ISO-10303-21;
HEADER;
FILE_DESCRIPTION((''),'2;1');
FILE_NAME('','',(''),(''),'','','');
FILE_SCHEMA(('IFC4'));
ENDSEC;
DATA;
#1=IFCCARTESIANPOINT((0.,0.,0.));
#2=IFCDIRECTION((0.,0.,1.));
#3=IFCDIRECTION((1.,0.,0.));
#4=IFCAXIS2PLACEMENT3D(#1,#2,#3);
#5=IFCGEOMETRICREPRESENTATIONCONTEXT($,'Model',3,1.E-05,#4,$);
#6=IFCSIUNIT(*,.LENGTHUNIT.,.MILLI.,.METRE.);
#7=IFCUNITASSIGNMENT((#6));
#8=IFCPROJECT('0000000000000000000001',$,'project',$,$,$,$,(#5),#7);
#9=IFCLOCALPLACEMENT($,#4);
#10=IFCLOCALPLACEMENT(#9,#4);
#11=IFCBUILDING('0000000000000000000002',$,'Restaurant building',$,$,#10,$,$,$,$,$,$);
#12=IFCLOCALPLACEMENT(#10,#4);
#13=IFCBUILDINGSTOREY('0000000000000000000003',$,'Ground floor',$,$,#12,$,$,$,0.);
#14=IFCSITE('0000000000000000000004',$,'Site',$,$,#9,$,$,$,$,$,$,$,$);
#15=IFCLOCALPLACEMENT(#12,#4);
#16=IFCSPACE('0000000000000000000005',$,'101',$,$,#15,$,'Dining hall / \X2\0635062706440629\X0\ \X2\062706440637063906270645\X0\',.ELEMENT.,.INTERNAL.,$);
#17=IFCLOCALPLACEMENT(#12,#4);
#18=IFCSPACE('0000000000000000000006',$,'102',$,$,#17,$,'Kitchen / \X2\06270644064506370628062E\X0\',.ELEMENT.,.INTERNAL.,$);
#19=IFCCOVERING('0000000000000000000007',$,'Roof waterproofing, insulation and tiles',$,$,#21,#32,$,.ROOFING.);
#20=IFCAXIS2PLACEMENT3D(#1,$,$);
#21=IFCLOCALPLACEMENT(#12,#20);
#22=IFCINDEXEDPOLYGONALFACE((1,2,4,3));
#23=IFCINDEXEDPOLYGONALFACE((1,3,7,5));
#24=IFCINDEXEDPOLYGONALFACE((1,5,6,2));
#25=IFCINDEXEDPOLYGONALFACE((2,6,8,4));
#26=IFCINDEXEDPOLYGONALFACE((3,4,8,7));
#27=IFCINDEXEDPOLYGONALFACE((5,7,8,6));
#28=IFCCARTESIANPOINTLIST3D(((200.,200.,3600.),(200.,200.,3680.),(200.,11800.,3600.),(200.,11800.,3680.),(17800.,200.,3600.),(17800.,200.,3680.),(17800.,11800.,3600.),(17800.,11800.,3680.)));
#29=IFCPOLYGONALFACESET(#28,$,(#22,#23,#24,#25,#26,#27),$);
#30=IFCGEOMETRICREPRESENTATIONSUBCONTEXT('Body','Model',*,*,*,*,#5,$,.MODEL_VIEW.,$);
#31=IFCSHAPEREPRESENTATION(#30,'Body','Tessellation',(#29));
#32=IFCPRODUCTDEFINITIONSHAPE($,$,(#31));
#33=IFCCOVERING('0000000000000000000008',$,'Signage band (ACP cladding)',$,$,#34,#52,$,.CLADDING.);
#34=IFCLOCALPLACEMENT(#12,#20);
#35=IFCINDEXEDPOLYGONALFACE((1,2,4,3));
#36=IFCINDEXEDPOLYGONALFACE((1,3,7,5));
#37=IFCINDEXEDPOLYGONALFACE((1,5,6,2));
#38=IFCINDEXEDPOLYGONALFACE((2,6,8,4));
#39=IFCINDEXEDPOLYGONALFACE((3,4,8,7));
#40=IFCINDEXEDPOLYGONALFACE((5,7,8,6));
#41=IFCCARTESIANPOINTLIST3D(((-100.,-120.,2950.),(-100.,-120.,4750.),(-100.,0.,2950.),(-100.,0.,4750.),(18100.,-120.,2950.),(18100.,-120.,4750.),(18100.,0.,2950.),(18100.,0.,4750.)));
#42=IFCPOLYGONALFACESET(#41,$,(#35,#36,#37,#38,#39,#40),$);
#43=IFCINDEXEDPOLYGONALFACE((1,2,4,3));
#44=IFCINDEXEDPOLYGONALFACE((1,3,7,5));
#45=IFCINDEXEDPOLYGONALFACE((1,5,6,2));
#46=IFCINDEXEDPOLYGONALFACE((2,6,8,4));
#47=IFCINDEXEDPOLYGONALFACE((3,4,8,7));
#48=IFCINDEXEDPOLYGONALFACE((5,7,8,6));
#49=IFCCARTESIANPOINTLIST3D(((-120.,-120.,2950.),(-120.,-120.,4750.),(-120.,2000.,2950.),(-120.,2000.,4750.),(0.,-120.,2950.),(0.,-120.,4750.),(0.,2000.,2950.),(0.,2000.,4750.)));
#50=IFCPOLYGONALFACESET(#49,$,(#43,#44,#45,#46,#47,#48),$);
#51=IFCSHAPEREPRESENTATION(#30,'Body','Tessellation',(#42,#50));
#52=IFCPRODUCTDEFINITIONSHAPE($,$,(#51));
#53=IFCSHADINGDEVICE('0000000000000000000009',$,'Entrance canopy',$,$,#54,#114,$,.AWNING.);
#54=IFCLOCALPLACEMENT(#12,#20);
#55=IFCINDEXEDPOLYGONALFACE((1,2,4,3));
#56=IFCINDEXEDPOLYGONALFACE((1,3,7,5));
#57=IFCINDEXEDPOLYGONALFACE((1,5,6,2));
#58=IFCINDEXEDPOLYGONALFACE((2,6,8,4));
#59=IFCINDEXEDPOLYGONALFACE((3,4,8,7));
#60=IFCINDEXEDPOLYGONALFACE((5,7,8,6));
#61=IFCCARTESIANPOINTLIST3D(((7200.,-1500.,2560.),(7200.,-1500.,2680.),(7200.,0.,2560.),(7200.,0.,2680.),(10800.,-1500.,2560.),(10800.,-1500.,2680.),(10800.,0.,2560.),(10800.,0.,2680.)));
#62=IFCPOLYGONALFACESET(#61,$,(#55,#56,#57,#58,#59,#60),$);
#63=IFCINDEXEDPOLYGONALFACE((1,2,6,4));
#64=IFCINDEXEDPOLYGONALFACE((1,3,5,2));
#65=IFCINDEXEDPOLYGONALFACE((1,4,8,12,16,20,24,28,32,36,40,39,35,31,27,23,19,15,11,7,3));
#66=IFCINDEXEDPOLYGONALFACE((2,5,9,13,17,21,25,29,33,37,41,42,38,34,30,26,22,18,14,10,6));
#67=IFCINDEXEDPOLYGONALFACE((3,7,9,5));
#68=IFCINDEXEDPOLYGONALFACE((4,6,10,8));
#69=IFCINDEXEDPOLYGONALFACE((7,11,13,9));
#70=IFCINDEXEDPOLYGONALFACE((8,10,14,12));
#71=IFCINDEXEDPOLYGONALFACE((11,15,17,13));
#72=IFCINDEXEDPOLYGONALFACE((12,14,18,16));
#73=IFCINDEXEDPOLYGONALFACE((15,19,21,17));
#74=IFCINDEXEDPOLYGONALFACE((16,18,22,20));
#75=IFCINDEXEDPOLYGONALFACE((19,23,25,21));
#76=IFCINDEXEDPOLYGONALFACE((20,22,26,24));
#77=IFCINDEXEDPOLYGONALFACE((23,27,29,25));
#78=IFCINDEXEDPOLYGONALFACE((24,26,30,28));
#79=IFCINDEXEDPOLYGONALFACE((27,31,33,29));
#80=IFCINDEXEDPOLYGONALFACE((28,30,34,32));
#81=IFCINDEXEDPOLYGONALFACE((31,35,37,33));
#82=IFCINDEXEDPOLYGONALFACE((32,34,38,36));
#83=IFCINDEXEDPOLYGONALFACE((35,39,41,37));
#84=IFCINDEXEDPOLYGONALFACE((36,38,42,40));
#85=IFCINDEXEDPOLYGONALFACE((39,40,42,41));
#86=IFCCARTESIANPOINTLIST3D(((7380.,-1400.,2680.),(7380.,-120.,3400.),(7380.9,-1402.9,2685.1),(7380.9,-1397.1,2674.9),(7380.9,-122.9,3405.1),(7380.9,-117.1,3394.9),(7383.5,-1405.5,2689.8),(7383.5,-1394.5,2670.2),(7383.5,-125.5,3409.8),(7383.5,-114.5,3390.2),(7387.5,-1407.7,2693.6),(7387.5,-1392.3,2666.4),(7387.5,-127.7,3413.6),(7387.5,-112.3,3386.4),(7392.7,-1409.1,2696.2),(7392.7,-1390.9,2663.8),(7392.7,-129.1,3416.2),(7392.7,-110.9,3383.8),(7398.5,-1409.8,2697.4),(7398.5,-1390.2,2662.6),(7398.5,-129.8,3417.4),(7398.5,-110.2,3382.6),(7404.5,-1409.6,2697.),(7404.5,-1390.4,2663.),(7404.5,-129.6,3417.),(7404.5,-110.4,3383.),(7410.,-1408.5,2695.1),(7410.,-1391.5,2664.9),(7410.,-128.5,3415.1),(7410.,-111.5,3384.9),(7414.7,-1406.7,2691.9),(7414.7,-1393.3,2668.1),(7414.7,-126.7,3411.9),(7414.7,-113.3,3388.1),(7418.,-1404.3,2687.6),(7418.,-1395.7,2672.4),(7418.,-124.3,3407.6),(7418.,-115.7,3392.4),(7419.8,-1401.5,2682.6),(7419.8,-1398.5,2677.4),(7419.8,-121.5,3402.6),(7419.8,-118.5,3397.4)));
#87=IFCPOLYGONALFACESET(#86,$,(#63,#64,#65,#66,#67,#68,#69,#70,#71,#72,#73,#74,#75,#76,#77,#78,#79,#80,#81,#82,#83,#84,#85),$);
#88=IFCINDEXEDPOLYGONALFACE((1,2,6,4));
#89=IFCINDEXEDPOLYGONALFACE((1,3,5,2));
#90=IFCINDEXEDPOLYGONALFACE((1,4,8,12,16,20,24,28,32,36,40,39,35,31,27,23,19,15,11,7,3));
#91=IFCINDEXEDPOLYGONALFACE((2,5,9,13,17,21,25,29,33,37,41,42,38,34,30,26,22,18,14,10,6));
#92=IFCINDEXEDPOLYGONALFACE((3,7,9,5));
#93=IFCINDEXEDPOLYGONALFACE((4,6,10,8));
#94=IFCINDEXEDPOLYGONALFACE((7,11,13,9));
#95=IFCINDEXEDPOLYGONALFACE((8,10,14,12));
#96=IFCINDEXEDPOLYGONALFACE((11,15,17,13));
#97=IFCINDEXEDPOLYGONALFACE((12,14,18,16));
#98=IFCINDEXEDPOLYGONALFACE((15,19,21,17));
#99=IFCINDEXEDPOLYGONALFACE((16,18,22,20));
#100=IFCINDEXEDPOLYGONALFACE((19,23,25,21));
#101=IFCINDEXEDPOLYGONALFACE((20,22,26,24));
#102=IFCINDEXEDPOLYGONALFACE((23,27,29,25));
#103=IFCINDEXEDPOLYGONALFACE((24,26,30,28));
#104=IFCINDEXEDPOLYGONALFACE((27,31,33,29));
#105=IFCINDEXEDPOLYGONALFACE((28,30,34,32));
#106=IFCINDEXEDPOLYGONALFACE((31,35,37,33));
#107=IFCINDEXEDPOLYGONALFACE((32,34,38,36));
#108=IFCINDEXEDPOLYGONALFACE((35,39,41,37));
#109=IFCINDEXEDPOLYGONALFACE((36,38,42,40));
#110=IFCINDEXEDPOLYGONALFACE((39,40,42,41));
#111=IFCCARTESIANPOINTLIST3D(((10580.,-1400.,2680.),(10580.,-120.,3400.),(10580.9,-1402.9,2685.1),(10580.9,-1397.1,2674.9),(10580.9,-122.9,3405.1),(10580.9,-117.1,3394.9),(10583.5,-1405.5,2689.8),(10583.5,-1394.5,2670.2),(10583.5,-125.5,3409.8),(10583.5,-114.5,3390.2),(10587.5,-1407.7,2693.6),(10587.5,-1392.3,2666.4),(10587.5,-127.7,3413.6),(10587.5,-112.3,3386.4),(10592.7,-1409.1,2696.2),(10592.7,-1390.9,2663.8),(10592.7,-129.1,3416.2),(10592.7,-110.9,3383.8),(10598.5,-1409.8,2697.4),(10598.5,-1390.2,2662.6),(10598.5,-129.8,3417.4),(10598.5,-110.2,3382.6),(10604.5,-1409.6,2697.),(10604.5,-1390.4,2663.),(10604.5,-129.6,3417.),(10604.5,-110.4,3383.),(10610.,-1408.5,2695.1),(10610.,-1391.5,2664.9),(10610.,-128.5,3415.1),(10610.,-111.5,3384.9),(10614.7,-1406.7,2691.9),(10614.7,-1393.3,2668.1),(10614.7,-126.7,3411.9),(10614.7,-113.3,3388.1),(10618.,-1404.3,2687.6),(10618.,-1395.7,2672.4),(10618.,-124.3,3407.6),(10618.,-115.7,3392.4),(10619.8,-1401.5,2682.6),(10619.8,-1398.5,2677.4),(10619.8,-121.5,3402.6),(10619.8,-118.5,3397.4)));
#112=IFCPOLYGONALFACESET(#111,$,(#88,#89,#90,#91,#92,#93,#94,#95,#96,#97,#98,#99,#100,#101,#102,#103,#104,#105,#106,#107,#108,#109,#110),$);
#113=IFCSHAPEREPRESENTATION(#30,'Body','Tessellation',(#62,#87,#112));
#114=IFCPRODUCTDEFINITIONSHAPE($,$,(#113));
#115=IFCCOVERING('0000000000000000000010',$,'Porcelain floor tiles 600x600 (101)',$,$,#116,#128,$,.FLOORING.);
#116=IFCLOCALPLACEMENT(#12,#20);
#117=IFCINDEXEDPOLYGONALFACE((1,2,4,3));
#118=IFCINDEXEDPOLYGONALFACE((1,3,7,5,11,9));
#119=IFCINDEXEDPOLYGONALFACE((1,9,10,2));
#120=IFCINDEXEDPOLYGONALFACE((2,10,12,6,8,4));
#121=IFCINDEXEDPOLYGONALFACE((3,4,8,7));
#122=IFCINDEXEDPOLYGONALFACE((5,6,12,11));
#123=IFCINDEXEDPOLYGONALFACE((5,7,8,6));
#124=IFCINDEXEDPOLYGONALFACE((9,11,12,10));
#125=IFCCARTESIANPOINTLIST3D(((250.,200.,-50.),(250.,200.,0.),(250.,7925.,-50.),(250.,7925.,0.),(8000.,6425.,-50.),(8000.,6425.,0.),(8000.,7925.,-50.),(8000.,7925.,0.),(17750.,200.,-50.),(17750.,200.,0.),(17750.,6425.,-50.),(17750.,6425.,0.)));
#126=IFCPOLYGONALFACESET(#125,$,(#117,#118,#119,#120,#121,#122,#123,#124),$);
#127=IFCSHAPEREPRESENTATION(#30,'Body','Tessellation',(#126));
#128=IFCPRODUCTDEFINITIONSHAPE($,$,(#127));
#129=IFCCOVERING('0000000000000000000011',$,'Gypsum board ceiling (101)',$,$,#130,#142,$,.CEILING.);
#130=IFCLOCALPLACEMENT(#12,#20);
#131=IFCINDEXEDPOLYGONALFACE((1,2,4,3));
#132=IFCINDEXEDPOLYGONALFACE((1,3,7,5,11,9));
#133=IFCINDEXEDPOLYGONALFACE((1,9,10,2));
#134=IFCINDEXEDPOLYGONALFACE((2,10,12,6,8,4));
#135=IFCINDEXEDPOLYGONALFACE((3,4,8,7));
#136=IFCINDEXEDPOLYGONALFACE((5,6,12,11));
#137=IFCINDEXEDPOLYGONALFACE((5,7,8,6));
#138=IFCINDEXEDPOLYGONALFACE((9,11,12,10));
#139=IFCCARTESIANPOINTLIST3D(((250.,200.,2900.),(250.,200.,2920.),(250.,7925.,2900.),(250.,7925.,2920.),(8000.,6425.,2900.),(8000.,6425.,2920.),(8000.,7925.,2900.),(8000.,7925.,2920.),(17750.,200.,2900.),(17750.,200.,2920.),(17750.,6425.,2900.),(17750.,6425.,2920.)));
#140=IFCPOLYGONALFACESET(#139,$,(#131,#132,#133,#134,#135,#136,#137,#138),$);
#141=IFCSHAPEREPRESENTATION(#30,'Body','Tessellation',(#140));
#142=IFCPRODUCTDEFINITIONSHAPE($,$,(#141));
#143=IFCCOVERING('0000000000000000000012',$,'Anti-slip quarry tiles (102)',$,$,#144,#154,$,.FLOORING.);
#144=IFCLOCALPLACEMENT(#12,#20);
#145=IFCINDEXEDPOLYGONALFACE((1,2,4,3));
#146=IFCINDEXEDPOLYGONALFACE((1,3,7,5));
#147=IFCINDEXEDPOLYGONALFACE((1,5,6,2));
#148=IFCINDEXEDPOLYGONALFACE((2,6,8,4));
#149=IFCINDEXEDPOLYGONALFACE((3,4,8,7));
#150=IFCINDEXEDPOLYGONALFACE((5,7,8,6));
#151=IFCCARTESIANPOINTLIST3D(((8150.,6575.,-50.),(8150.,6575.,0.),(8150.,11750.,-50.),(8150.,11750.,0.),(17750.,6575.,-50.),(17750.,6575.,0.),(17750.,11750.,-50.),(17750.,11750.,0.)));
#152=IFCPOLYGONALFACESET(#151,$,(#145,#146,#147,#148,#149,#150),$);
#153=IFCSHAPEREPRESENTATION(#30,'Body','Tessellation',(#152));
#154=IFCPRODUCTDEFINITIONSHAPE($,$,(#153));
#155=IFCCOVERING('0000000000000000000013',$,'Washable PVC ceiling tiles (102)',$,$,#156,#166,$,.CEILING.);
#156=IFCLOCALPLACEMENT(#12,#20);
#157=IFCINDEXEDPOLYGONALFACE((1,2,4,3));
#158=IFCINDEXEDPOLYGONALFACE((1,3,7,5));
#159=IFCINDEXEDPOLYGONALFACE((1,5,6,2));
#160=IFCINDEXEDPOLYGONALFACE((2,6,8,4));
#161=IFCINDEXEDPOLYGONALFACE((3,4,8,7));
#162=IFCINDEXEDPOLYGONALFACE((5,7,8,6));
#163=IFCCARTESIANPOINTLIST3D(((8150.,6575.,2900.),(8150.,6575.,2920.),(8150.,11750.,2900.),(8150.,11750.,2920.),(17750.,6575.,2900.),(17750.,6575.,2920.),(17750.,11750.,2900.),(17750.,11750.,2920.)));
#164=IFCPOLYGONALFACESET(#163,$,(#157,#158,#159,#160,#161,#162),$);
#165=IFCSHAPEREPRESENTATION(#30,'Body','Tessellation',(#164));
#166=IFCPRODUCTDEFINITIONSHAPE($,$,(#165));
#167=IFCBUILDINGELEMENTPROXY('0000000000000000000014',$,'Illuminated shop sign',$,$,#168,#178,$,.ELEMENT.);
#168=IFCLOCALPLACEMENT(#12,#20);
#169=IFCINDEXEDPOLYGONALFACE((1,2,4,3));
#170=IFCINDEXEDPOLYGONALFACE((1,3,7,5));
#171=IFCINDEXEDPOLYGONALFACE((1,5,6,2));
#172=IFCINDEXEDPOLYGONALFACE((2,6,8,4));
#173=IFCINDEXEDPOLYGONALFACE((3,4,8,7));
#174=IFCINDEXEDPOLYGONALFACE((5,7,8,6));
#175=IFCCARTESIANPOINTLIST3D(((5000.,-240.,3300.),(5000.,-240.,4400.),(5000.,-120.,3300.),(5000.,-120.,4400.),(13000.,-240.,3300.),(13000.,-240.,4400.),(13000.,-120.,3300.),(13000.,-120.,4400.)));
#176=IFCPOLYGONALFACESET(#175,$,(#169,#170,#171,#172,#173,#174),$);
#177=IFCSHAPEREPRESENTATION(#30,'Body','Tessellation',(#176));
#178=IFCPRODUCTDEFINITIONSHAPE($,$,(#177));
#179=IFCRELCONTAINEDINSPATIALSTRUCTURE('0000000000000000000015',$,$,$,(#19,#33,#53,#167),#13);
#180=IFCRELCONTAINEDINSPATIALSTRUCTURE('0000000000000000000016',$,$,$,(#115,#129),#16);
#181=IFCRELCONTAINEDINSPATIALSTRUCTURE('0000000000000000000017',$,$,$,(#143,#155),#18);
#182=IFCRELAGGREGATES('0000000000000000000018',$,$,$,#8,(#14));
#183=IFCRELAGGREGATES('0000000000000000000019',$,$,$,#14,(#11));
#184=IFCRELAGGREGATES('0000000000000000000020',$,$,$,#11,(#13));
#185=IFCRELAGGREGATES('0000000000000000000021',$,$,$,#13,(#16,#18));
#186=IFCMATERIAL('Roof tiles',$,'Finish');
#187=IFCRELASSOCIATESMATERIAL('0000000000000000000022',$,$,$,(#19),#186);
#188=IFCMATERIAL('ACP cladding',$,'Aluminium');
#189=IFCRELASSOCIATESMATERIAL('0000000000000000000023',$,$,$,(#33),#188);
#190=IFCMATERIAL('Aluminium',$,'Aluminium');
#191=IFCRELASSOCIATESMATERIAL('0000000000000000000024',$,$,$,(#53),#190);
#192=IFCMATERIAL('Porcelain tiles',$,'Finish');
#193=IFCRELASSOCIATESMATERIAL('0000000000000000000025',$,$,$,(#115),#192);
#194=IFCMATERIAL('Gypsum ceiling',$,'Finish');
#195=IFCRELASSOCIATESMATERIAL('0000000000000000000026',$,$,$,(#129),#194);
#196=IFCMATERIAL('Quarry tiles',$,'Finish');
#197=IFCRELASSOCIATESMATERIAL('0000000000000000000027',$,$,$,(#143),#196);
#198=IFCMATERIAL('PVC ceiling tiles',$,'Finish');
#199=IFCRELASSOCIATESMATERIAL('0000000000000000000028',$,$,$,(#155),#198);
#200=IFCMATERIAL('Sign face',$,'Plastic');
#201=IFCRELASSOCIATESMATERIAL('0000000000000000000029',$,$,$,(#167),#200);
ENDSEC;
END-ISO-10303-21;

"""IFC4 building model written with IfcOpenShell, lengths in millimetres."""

from ifc_helpers import new_model, si_unit, frame, origin, origin_with_axes, origin_2d, place, context, subcontext, project, spatial, polyline, rectangle, circle, outline, extrude, material, element, save


model = new_model("IFC4")

# Units and contexts
model_context = context("Model", 3, precision=1e-05, world=origin_with_axes())
body_context = subcontext(model_context, "Body", "Model", "MODEL_VIEW")
ifc_project = project(units=[si_unit("LENGTHUNIT", "METRE", prefix="MILLI")], contexts=[model_context])

# Site, building, storey
site_placement = place(None, origin_with_axes())
site = spatial("IfcSite", under=ifc_project, at=site_placement, Name="Site")
building_placement = place(site_placement, origin_with_axes())
building = spatial("IfcBuilding", under=site, at=building_placement, Name="Restaurant building")
storey_placement = place(building_placement, origin_with_axes())
storey = spatial("IfcBuildingStorey", under=building, at=storey_placement, Name="Ground floor", Elevation=0.0)

# Coverings
ifc_material_1 = material(Name="Roof tiles", Category="Finish")
covering_1_placement = place(storey_placement, origin())
element("IfcCovering", 1, at=covering_1_placement, inside=storey, material=ifc_material_1, Name="Roof waterproofing, insulation and tiles", PredefinedType="ROOFING", context=body_context, shape_type="SweptSolid", body=[
    extrude(rectangle(XDim=17600.0, YDim=11600.0, at=origin_2d()), frame((9000.0, 6000.0, 3600.0)), (0.0, 0.0, 1.0), 80.0),
])
ifc_material_2 = material(Name="ACP cladding", Category="Aluminium")
covering_2_placement = place(storey_placement, origin())
element("IfcCovering", 2, at=covering_2_placement, inside=storey, material=ifc_material_2, Name="Signage band (ACP cladding)", PredefinedType="CLADDING", context=body_context, shape_type="SweptSolid", body=[
    extrude(rectangle(XDim=18200.0, YDim=120.0, at=origin_2d()), frame((9000.0, -60.0, 2950.0)), (0.0, 0.0, 1.0), 1800.0),
    extrude(rectangle(XDim=120.0, YDim=2120.0, at=origin_2d()), frame((-60.0, 940.0, 2950.0)), (0.0, 0.0, 1.0), 1800.0),
])

# Shading device
ifc_material_3 = material(Name="Aluminium", Category="Aluminium")
shading_device_placement = place(storey_placement, origin())
element("IfcShadingDevice", 3, at=shading_device_placement, inside=storey, material=ifc_material_3, Name="Entrance canopy", PredefinedType="AWNING", context=body_context, shape_type="SweptSolid", body=[
    extrude(rectangle(XDim=3600.0, YDim=1500.0, at=origin_2d()), frame((9000.0, -750.0, 2560.0)), (0.0, 0.0, 1.0), 120.0),
    extrude(circle(Radius=20.0, at=origin_2d()), frame((7400.0, -1400.0, 2680.0), z_axis=(0.0, 0.871576, 0.490261), x_axis=(-1.0, 0.0, 0.0)), (0.0, 0.0, 1.0), 1468.6),
    extrude(circle(Radius=20.0, at=origin_2d()), frame((10600.0, -1400.0, 2680.0), z_axis=(0.0, 0.871576, 0.490261), x_axis=(-1.0, 0.0, 0.0)), (0.0, 0.0, 1.0), 1468.6),
])

# Shared definitions
space_1_placement = place(storey_placement, origin_with_axes())
space_1 = spatial("IfcSpace", under=storey, at=space_1_placement, Name="101", LongName="Dining hall / صالة الطعام", CompositionType="ELEMENT", PredefinedType="INTERNAL")

# Coverings
ifc_material_4 = material(Name="Porcelain tiles", Category="Finish")
covering_3_placement = place(storey_placement, origin())
element("IfcCovering", 4, at=covering_3_placement, inside=space_1, material=ifc_material_4, Name="Porcelain floor tiles 600x600 (101)", PredefinedType="FLOORING", context=body_context, shape_type="SweptSolid", body=[
    extrude(outline(polyline([(250.0, 200.0), (17750.0, 200.0), (17750.0, 6425.0), (8000.0, 6425.0), (8000.0, 7925.0), (250.0, 7925.0), (250.0, 200.0)])), frame((0.0, 0.0, -50.0)), (0.0, 0.0, 1.0), 50.0),
])
ifc_material_5 = material(Name="Gypsum ceiling", Category="Finish")
covering_4_placement = place(storey_placement, origin())
element("IfcCovering", 5, at=covering_4_placement, inside=space_1, material=ifc_material_5, Name="Gypsum board ceiling (101)", PredefinedType="CEILING", context=body_context, shape_type="SweptSolid", body=[
    extrude(outline(polyline([(250.0, 200.0), (17750.0, 200.0), (17750.0, 6425.0), (8000.0, 6425.0), (8000.0, 7925.0), (250.0, 7925.0), (250.0, 200.0)])), frame((0.0, 0.0, 2900.0)), (0.0, 0.0, 1.0), 20.0),
])

# Shared definitions
space_2_placement = place(storey_placement, origin_with_axes())
space_2 = spatial("IfcSpace", under=storey, at=space_2_placement, Name="102", LongName="Kitchen / المطبخ", CompositionType="ELEMENT", PredefinedType="INTERNAL")

# Coverings
ifc_material_6 = material(Name="Quarry tiles", Category="Finish")
covering_5_placement = place(storey_placement, origin())
element("IfcCovering", 6, at=covering_5_placement, inside=space_2, material=ifc_material_6, Name="Anti-slip quarry tiles (102)", PredefinedType="FLOORING", context=body_context, shape_type="SweptSolid", body=[
    extrude(outline(polyline([(8150.0, 6575.0), (17750.0, 6575.0), (17750.0, 11750.0), (8150.0, 11750.0), (8150.0, 6575.0)])), frame((0.0, 0.0, -50.0)), (0.0, 0.0, 1.0), 50.0),
])
ifc_material_7 = material(Name="PVC ceiling tiles", Category="Finish")
covering_6_placement = place(storey_placement, origin())
element("IfcCovering", 7, at=covering_6_placement, inside=space_2, material=ifc_material_7, Name="Washable PVC ceiling tiles (102)", PredefinedType="CEILING", context=body_context, shape_type="SweptSolid", body=[
    extrude(outline(polyline([(8150.0, 6575.0), (17750.0, 6575.0), (17750.0, 11750.0), (8150.0, 11750.0), (8150.0, 6575.0)])), frame((0.0, 0.0, 2900.0)), (0.0, 0.0, 1.0), 20.0),
])

# Building element proxy
ifc_material_8 = material(Name="Sign face", Category="Plastic")
proxy_placement = place(storey_placement, origin())
element("IfcBuildingElementProxy", 8, at=proxy_placement, inside=storey, material=ifc_material_8, Name="Illuminated shop sign", PredefinedType="ELEMENT", context=body_context, shape_type="SweptSolid", body=[
    extrude(rectangle(XDim=8000.0, YDim=120.0, at=origin_2d()), frame((9000.0, -180.0, 3300.0)), (0.0, 0.0, 1.0), 1100.0),
])

save(model, "model.ifc")
